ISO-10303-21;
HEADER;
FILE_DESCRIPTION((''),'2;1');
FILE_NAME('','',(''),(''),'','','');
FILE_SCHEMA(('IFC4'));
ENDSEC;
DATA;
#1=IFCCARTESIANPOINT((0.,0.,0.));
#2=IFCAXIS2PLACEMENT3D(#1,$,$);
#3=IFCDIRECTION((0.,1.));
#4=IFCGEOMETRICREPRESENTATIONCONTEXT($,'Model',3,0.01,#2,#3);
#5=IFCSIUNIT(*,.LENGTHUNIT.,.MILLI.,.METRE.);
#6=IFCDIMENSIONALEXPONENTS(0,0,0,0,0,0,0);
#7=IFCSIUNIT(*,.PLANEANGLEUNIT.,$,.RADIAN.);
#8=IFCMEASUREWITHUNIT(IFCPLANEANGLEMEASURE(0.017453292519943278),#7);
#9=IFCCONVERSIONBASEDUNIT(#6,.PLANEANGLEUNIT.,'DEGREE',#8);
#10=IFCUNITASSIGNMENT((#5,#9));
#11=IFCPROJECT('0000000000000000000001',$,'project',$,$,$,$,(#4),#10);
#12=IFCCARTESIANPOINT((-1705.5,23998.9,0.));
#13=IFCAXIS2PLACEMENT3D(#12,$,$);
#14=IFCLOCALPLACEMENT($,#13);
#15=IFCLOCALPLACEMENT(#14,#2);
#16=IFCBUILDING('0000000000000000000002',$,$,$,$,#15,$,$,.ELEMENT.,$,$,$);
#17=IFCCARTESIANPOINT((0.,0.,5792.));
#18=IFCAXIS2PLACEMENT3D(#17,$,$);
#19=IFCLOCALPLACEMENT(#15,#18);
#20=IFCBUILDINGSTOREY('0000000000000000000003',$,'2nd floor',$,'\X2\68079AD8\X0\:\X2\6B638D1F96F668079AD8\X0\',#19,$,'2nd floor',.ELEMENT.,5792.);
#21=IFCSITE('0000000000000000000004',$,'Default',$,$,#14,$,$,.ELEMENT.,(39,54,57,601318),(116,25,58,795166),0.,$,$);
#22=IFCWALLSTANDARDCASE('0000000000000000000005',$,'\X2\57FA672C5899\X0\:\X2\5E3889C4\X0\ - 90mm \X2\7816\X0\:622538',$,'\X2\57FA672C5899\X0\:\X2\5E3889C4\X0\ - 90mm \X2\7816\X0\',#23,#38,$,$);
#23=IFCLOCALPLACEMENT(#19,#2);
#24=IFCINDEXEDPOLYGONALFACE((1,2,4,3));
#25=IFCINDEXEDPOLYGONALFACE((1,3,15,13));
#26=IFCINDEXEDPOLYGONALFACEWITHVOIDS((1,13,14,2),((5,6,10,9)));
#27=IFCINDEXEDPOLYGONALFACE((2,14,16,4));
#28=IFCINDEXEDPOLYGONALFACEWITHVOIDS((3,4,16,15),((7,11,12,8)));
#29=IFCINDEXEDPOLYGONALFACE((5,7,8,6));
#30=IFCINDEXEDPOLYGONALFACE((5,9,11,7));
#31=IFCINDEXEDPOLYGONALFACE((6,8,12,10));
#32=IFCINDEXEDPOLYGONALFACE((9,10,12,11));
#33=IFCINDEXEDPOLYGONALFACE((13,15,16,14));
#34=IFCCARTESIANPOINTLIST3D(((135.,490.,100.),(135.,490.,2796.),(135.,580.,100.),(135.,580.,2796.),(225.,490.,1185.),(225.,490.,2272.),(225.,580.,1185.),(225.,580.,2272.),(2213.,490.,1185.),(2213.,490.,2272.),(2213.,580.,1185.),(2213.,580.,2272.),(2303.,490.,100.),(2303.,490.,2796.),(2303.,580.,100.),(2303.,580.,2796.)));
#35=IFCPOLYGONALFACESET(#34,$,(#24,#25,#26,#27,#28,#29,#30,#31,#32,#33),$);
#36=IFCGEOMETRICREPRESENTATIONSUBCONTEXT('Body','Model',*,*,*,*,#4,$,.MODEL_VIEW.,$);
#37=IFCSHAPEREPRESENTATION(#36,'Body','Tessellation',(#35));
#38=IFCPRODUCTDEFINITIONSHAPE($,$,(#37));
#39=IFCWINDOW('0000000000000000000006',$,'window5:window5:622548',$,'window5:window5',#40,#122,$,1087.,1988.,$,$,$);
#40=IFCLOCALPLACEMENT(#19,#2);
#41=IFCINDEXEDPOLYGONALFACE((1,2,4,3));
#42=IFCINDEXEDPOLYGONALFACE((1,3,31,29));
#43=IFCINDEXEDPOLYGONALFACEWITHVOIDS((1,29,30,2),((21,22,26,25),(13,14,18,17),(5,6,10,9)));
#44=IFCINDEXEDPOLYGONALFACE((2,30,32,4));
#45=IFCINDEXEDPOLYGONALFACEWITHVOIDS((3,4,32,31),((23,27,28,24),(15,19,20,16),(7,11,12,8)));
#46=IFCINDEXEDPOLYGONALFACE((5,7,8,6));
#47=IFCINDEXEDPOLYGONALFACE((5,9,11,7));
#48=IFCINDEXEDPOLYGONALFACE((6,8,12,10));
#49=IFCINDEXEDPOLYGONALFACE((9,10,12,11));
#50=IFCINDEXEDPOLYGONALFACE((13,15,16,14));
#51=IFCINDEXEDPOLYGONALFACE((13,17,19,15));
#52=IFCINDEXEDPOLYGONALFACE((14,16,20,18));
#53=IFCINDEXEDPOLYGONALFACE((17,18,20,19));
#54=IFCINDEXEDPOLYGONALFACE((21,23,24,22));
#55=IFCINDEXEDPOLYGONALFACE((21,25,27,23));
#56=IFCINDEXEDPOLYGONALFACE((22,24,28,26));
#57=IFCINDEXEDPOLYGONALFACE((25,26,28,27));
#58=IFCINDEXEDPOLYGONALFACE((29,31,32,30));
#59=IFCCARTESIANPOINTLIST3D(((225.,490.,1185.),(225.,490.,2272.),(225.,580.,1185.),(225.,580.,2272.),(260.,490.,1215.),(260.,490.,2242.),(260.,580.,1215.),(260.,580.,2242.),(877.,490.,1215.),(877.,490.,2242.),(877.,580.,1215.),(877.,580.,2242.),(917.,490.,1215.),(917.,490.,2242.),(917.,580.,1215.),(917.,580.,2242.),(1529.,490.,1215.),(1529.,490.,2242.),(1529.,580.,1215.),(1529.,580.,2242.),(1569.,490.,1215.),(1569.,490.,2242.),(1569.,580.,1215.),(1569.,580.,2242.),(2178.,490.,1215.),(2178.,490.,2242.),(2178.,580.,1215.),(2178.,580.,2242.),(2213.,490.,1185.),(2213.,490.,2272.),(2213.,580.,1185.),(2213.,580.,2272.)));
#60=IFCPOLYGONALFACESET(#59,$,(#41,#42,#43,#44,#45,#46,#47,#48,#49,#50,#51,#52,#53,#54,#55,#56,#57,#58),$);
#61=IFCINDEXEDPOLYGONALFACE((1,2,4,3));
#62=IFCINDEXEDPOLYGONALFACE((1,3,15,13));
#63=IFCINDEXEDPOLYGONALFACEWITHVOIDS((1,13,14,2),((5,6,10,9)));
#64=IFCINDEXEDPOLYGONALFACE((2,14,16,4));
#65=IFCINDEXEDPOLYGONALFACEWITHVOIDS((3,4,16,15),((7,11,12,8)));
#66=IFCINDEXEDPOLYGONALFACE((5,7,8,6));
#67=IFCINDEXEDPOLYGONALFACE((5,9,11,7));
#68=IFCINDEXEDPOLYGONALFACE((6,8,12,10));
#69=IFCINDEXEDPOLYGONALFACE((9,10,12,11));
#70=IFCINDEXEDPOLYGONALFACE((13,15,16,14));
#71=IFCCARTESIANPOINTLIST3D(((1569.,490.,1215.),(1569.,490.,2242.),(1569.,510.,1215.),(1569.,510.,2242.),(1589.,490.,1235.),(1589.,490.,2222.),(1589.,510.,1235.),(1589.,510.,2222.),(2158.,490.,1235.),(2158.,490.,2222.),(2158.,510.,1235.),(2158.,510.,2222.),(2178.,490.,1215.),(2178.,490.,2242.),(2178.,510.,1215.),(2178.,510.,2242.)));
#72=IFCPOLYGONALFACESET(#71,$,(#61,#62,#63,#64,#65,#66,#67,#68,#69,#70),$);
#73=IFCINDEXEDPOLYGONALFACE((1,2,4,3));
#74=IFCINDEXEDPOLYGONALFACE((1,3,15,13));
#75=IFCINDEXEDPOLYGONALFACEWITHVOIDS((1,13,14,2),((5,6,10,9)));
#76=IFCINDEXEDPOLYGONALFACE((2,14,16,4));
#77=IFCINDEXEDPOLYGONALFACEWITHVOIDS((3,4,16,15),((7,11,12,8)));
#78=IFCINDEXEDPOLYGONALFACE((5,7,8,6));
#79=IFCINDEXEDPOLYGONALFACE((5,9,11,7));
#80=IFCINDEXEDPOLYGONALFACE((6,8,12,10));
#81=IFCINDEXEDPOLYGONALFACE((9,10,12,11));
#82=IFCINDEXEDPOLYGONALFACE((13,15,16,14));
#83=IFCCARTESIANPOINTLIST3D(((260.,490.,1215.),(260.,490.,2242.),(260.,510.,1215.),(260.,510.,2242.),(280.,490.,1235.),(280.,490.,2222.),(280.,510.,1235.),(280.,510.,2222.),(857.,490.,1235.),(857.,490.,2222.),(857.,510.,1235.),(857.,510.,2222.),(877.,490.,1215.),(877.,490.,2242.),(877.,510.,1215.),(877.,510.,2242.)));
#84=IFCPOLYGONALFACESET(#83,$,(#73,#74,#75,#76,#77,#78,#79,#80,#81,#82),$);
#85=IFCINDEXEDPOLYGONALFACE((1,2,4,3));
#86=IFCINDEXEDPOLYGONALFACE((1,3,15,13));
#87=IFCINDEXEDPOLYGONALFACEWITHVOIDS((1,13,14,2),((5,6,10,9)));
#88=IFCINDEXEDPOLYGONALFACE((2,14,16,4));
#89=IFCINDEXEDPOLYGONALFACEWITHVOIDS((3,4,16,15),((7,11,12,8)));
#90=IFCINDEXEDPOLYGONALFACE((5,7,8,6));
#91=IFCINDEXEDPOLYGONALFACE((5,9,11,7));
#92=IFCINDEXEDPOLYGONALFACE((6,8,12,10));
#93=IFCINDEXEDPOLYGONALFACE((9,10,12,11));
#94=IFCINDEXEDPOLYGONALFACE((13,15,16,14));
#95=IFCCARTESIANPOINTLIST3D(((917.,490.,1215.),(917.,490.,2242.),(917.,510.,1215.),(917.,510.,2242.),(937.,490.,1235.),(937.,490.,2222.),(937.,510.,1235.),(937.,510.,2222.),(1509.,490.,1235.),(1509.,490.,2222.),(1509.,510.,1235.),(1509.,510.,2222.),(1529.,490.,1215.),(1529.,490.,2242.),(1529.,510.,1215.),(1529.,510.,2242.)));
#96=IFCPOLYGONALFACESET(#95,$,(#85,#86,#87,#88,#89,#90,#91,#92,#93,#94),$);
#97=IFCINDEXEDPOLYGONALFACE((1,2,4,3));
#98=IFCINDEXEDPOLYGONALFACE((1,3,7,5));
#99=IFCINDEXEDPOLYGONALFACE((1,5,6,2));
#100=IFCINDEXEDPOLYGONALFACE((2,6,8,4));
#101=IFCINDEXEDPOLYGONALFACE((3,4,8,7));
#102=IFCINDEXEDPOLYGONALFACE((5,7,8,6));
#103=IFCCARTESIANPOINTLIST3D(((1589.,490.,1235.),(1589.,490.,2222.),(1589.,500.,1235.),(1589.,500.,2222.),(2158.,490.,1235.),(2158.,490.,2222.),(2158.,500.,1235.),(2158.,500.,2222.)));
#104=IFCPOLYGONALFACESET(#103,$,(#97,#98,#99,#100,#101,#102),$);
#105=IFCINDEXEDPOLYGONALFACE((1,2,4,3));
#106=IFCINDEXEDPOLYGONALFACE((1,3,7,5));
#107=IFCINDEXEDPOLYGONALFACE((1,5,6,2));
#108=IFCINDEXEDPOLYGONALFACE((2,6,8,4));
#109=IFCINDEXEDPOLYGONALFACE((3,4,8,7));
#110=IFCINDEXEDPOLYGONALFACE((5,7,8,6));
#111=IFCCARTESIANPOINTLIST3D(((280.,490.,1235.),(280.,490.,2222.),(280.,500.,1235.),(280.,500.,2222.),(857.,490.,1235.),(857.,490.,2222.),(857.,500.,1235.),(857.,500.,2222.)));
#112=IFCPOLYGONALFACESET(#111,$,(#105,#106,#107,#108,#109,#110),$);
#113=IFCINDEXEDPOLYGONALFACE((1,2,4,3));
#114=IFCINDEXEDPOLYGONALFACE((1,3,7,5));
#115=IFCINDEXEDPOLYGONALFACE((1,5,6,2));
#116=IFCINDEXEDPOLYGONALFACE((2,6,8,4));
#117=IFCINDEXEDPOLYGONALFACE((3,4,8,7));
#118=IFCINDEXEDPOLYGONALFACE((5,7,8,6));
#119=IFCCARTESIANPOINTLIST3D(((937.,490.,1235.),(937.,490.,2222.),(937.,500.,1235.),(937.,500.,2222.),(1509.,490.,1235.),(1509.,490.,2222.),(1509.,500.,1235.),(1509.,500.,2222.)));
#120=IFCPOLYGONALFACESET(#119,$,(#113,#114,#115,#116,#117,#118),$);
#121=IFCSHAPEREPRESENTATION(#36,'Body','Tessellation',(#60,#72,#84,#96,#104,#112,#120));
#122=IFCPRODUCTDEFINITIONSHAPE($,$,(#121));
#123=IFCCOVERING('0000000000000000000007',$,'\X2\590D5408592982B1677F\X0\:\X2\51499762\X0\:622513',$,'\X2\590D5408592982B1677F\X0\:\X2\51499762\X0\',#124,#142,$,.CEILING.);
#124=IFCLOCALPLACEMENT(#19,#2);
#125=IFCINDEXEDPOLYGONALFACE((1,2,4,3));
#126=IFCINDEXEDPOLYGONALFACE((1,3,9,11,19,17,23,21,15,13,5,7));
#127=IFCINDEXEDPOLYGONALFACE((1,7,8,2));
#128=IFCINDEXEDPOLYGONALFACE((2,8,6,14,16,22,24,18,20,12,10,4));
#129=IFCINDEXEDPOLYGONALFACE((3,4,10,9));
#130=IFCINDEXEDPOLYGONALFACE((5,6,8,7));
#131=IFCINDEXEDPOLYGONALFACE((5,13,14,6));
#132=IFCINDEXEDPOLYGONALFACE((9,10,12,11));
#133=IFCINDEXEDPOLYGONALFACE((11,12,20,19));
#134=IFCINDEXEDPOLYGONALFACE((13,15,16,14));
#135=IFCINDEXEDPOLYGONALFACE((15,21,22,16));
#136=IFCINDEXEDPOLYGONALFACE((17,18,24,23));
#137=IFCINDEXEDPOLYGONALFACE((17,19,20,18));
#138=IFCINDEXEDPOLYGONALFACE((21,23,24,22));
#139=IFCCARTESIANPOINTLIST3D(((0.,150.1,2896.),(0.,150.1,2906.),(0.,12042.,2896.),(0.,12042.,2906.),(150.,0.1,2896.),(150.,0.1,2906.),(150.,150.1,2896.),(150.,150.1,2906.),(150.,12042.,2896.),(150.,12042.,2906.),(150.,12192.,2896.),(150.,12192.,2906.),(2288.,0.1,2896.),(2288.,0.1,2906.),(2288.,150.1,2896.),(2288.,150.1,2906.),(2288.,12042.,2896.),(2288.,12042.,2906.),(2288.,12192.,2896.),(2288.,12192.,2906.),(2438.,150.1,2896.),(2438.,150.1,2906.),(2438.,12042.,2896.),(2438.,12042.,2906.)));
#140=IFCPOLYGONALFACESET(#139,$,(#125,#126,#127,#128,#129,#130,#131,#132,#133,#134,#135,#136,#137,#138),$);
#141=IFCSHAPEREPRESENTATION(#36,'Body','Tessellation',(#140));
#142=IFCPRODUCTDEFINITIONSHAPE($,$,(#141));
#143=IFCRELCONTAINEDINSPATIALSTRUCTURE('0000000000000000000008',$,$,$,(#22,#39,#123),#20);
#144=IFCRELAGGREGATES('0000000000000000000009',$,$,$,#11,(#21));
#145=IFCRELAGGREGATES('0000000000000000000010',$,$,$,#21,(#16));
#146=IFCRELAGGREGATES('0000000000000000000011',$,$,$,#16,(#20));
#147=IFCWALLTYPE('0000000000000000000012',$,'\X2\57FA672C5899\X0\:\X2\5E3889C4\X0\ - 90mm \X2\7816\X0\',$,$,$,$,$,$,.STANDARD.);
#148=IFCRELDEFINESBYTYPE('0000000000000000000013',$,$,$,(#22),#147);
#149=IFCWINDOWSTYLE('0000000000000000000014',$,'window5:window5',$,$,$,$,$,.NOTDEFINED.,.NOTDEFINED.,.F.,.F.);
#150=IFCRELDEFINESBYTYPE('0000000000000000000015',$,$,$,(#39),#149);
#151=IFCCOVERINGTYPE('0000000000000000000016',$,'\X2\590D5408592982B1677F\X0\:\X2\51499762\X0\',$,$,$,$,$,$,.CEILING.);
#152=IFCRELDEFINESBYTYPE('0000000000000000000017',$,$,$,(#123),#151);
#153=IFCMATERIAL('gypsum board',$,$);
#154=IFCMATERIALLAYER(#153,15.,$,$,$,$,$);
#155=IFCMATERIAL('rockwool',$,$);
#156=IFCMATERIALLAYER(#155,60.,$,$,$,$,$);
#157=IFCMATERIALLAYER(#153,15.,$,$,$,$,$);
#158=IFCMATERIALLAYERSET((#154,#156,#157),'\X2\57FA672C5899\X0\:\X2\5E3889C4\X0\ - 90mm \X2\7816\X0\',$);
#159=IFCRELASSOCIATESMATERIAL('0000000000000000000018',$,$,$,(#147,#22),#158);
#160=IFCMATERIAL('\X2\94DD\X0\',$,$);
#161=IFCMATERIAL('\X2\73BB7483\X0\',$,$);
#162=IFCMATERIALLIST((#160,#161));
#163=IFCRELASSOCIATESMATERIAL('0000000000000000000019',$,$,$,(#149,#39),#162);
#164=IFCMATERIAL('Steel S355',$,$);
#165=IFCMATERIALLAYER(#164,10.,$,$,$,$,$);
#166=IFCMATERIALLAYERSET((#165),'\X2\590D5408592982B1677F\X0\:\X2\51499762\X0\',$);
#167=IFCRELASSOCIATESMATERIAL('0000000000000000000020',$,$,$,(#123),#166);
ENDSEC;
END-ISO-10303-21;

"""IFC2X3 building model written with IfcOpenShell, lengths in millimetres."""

from ifc_helpers import new_model, entity, si_unit, converted_unit, direction, frame, frame_2d, origin, place, context, subcontext, project, spatial, polyline, rectangle, outline, extrude, source, transform, mapped, material, material_list, layer, layer_set, layer_usage, type_object, type_shapes, element, fill, save


model = new_model("IFC2X3")

# Units and contexts
model_context = context("Model", 3, precision=0.01, world=origin(), true_north=direction((0.0, 1.0)))
body_context = subcontext(model_context, "Body", "Model", "MODEL_VIEW")
ifc_project = project(units=[si_unit("LENGTHUNIT", "METRE", prefix="MILLI"), converted_unit("PLANEANGLEUNIT", "DEGREE", entity("IfcPlaneAngleMeasure", 0.017453292519943278), si_unit("PLANEANGLEUNIT", "RADIAN"), dimensions=[0, 0, 0, 0, 0, 0, 0])], contexts=[model_context])

# Site, building, storey
site_placement = place(None, frame((-1705.5, 23998.9, 0.0)))
site = spatial("IfcSite", under=ifc_project, at=site_placement, Name="Default", CompositionType="ELEMENT", RefLatitude=(39, 54, 57, 601318), RefLongitude=(116, 25, 58, 795166), RefElevation=0.0)
building_placement = place(site_placement, origin())
building = spatial("IfcBuilding", under=site, at=building_placement, CompositionType="ELEMENT")
storey_placement = place(building_placement, frame((0.0, 0.0, 5792.0)))
storey = spatial("IfcBuildingStorey", under=building, at=storey_placement, Name="2nd floor", ObjectType="标高:正负零标高", LongName="2nd floor", CompositionType="ELEMENT", Elevation=5792.0)

# Shared definitions
ifc_material_1 = material(Name="Steel S355")

# Wall, opening, window
ifc_material_2 = material(Name="gypsum board")
ifc_layer_1 = layer(ifc_material_2, 15.0)
ifc_material_3 = material(Name="rockwool")
ifc_layer_2 = layer(ifc_material_3, 60.0)
ifc_layer_3 = layer(ifc_material_2, 15.0)
ifc_layer_set_1 = layer_set([ifc_layer_1, ifc_layer_2, ifc_layer_3], Name="基本墙:常规 - 90mm 砖")
ifc_layer_usage_1 = layer_usage(ifc_layer_set_1, "AXIS2", "NEGATIVE", 45.0)
wall_type = type_object("IfcWallType", Name="基本墙:常规 - 90mm 砖", PredefinedType="STANDARD", material=ifc_layer_set_1)
wall_placement = place(storey_placement, frame((2303.0, 535.0, 100.0), z_axis=(0.0, 0.0, 1.0), x_axis=(-1.0, 0.0, 0.0)))
wall = element("IfcWallStandardCase", 1, at=wall_placement, inside=storey, type_object=wall_type, material=ifc_layer_usage_1, Name="基本墙:常规 - 90mm 砖:622538", ObjectType="基本墙:常规 - 90mm 砖", context=body_context, shape_type="SweptSolid", body=[
    extrude(rectangle(XDim=2168.0, YDim=90.0, at=frame_2d((1084.0, 0.0), x_axis=(-1.0, 0.0))), origin(), (0.0, 0.0, 1.0), 2696.0),
])
opening_1_placement = place(wall_placement, frame((90.0, -45.0, 1085.0)))
opening_1 = element("IfcOpeningElement", 2, at=opening_1_placement, cuts=wall, ObjectType="Opening", context=body_context, shape_type="SweptSolid", body=[
    extrude(rectangle(XDim=1087.0, YDim=1988.0, at=frame_2d((543.5, 994.0), x_axis=(1.0, 0.0))), frame((0.0, 0.0, 0.0), z_axis=(0.0, 1.0, 0.0), x_axis=(0.0, 0.0, 1.0)), (0.0, 0.0, 1.0), 90.0),
])
ifc_material_4 = material(Name="铝")
ifc_material_5 = material(Name="玻璃")
ifc_material_list = material_list([ifc_material_4, ifc_material_5])
window_style = type_object("IfcWindowStyle", Name="window5:window5", ConstructionType="NOTDEFINED", OperationType="NOTDEFINED", ParameterTakesPrecedence=False, Sizeable=False, material=ifc_material_list)
shared_shape = source(origin(), body_context, "Body", "SweptSolid", [
    extrude(outline(polyline([(-994.0, -543.5), (994.0, -543.5), (994.0, 543.5), (-994.0, 543.5), (-994.0, -543.5)]), holes=[polyline([(-959.0, 513.5), (-342.0, 513.5), (-342.0, -513.5), (-959.0, -513.5), (-959.0, 513.5)]), polyline([(-302.0, 513.5), (310.0, 513.5), (310.0, -513.5), (-302.0, -513.5), (-302.0, 513.5)]), polyline([(350.0, 513.5), (959.0, 513.5), (959.0, -513.5), (350.0, -513.5), (350.0, 513.5)])]), frame((994.0, 0.0, 543.5), z_axis=(0.0, 1.0, 0.0), x_axis=(-1.0, 0.0, 0.0)), (0.0, 0.0, 1.0), 90.0),
    extrude(outline(polyline([(-304.5, -513.5), (304.5, -513.5), (304.5, 513.5), (-304.5, 513.5), (-304.5, -513.5)]), holes=[polyline([(-284.5, -493.5), (-284.5, 493.5), (284.5, 493.5), (284.5, -493.5), (-284.5, -493.5)])]), frame((339.5, 70.0, 543.5), z_axis=(0.0, 1.0, 0.0), x_axis=(1.0, 0.0, 0.0)), (0.0, 0.0, 1.0), 20.0),
    extrude(outline(polyline([(-308.5, -513.5), (308.5, -513.5), (308.5, 513.5), (-308.5, 513.5), (-308.5, -513.5)]), holes=[polyline([(-288.5, -493.5), (-288.5, 493.5), (288.5, 493.5), (288.5, -493.5), (-288.5, -493.5)])]), frame((1644.5, 70.0, 543.5), z_axis=(0.0, 1.0, 0.0), x_axis=(1.0, 0.0, 0.0)), (0.0, 0.0, 1.0), 20.0),
    extrude(outline(polyline([(-306.0, -513.5), (306.0, -513.5), (306.0, 513.5), (-306.0, 513.5), (-306.0, -513.5)]), holes=[polyline([(-286.0, -493.5), (-286.0, 493.5), (286.0, 493.5), (286.0, -493.5), (-286.0, -493.5)])]), frame((990.0, 70.0, 543.5), z_axis=(0.0, 1.0, 0.0), x_axis=(1.0, 0.0, 0.0)), (0.0, 0.0, 1.0), 20.0),
    extrude(rectangle(XDim=10.0, YDim=569.0, at=frame_2d((0.0, 0.0), x_axis=(1.0, 0.0))), frame((339.5, 85.0, 50.0), z_axis=(0.0, 0.0, 1.0), x_axis=(0.0, 1.0, 0.0)), (0.0, 0.0, 1.0), 987.0),
    extrude(rectangle(XDim=10.0, YDim=577.0, at=frame_2d((0.0, 0.0), x_axis=(1.0, 0.0))), frame((1644.5, 85.0, 50.0), z_axis=(0.0, 0.0, 1.0), x_axis=(0.0, 1.0, 0.0)), (0.0, 0.0, 1.0), 987.0),
    extrude(rectangle(XDim=10.0, YDim=572.0, at=frame_2d((0.0, 0.0), x_axis=(1.0, 0.0))), frame((990.0, 85.0, 50.0), z_axis=(0.0, 0.0, 1.0), x_axis=(0.0, 1.0, 0.0)), (0.0, 0.0, 1.0), 987.0),
])
type_shapes(window_style, [shared_shape])
window_placement = place(opening_1_placement, origin())
window = element("IfcWindow", 3, at=window_placement, inside=storey, type_object=window_style, material=ifc_material_list, Name="window5:window5:622548", ObjectType="window5:window5", OverallHeight=1087.0, OverallWidth=1988.0, context=body_context, shape_type="MappedRepresentation", body=[
    mapped(shared_shape, transform((0.0, 0.0, 0.0), scale=1.0)),
])
fill(opening_1, window)

# Covering
ifc_layer_4 = layer(ifc_material_1, 10.0)
ifc_layer_set_2 = layer_set([ifc_layer_4], Name="复合天花板:光面")
ifc_layer_usage_2 = layer_usage(ifc_layer_set_2, "AXIS3", "NEGATIVE", 10.0)
covering_type = type_object("IfcCoveringType", Name="复合天花板:光面", PredefinedType="CEILING")
covering_placement = place(storey_placement, origin())
element("IfcCovering", 4, at=covering_placement, inside=storey, type_object=covering_type, material=ifc_layer_usage_2, Name="复合天花板:光面:622513", ObjectType="复合天花板:光面", PredefinedType="CEILING", context=body_context, shape_type="SweptSolid", body=[
    extrude(outline(polyline([(5946.0, -1069.0), (6096.0, -1069.0), (6096.0, 1069.0), (5945.9, 1069.0), (5945.9, 1219.0), (-5946.0, 1219.0), (-5946.0, 1069.0), (-6096.0, 1069.0), (-6096.0, -1069.0), (-5946.0, -1069.0), (-5946.0, -1219.0), (5946.0, -1219.0), (5946.0, -1069.0)])), frame((1219.0, 6096.0, 2896.0), z_axis=(0.0, 0.0, 1.0), x_axis=(0.0, 1.0, 0.0)), (0.0, 0.0, 1.0), 10.0),
])

save(model, "model.ifc")
